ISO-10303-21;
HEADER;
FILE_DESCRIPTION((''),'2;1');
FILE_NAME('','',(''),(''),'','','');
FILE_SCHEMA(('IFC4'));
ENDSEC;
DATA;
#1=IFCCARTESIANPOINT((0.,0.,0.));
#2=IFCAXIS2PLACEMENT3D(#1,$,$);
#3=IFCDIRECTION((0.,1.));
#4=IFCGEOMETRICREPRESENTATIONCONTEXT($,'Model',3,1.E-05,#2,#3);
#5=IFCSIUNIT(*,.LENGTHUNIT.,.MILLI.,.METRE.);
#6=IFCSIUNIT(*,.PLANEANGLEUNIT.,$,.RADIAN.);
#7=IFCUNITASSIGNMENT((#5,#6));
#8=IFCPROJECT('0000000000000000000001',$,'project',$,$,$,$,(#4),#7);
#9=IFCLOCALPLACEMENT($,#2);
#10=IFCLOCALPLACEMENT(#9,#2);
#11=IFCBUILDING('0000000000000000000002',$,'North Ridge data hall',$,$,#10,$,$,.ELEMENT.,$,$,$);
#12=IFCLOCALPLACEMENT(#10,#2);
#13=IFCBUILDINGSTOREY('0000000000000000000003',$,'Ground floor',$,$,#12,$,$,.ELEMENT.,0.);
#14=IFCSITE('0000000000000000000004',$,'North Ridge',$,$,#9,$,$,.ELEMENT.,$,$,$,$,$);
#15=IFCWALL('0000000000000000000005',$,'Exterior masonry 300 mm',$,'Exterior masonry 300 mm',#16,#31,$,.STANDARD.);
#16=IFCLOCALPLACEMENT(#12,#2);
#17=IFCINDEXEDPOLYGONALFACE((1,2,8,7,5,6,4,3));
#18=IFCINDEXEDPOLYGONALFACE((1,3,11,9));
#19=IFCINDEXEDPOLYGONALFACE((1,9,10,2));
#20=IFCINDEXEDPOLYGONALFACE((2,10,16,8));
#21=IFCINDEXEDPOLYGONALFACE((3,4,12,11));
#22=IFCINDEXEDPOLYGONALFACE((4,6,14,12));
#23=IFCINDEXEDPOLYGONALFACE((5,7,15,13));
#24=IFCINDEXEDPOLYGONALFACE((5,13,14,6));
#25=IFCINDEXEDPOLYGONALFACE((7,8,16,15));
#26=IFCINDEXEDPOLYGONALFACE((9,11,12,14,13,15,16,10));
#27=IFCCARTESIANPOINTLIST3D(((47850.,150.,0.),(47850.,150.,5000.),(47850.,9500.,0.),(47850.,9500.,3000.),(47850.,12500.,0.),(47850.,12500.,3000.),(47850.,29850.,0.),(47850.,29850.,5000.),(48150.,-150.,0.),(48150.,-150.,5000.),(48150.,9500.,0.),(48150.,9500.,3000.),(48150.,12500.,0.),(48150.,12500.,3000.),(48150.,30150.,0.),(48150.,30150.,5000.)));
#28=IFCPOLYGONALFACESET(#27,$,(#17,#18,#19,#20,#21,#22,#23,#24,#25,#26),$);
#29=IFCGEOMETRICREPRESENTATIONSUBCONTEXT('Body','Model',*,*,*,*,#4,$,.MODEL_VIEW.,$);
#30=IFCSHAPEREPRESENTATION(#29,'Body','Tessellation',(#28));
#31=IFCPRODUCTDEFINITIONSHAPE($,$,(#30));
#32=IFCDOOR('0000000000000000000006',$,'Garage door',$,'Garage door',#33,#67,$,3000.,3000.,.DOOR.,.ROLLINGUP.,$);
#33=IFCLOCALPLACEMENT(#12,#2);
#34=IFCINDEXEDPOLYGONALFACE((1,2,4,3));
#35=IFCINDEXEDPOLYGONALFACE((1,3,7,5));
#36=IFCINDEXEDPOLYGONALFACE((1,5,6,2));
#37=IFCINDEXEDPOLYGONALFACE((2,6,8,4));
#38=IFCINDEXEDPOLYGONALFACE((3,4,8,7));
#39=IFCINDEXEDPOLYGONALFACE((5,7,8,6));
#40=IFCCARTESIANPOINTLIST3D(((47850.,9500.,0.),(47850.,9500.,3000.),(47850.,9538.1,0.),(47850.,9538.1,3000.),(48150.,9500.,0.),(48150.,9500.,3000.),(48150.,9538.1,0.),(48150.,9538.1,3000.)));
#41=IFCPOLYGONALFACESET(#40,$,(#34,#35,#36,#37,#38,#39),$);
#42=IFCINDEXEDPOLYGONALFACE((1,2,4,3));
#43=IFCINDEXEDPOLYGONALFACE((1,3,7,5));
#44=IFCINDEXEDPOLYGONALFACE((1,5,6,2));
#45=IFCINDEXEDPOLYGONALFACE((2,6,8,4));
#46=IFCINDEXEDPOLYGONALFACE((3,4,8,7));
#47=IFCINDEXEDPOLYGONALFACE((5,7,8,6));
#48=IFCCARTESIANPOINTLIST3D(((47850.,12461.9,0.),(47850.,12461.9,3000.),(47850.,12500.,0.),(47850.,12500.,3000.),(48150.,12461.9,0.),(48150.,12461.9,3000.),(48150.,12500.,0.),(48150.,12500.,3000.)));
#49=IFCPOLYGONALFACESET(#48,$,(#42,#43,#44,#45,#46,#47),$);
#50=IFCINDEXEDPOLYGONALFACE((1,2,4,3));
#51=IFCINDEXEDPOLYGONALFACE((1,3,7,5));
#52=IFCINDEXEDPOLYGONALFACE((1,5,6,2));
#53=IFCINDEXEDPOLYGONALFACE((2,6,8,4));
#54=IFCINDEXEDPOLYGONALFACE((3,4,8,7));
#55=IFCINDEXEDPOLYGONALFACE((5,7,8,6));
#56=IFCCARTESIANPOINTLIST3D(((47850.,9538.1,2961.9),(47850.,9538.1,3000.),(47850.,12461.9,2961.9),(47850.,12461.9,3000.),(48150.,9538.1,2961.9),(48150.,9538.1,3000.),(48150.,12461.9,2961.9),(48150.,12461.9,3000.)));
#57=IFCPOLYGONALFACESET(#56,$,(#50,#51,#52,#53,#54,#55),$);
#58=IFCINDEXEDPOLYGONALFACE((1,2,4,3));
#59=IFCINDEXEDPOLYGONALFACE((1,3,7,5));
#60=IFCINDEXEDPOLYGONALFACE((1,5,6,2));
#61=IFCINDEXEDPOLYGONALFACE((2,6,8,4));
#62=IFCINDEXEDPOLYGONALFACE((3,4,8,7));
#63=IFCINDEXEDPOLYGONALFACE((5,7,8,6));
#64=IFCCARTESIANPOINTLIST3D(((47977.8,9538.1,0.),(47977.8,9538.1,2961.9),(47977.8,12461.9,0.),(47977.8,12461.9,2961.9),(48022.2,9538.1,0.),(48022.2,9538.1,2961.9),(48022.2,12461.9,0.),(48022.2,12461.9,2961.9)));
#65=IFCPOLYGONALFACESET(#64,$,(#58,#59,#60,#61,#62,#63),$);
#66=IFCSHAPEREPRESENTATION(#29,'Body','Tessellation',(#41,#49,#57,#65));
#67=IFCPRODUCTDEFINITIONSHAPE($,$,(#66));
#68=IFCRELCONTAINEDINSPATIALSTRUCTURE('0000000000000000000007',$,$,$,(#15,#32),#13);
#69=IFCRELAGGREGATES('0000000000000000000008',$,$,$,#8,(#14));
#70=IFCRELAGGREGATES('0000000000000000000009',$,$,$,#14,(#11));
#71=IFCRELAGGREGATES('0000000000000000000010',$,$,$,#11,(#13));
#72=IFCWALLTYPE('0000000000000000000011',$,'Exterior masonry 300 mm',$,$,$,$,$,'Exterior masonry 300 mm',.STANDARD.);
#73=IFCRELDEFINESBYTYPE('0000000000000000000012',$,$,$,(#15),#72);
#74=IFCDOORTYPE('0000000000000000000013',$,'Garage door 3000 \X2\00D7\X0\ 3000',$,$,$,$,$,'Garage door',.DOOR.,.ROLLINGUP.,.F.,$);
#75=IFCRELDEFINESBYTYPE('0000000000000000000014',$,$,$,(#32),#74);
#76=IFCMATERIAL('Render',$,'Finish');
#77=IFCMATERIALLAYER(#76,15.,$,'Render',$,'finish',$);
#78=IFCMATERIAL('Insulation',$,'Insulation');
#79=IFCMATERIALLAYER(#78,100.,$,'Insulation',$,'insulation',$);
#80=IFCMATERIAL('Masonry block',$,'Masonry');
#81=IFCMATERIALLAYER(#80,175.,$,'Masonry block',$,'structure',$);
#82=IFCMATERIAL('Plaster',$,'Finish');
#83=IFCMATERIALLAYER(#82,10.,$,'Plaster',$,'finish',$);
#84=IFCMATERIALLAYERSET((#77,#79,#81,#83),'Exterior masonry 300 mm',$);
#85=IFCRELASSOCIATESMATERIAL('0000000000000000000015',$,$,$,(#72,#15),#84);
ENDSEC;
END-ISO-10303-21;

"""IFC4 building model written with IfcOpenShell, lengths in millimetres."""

from ifc_helpers import new_model, si_unit, direction, frame, origin, origin_with_axes, place, context, subcontext, project, spatial, polyline, outline, extrude, material, layer, layer_set, layer_usage, type_object, element, fill, save


model = new_model("IFC4")

# Units and contexts
model_context = context("Model", 3, precision=1e-05, world=origin(), true_north=direction((0.0, 1.0)))
body_context = subcontext(model_context, "Body", "Model", "MODEL_VIEW")
ifc_project = project(units=[si_unit("LENGTHUNIT", "METRE", prefix="MILLI"), si_unit("PLANEANGLEUNIT", "RADIAN")], contexts=[model_context])

# Site, building, storey
site_placement = place(None, origin())
site = spatial("IfcSite", under=ifc_project, at=site_placement, Name="North Ridge", CompositionType="ELEMENT")
building_placement = place(site_placement, origin())
building = spatial("IfcBuilding", under=site, at=building_placement, Name="North Ridge data hall", CompositionType="ELEMENT")
storey_placement = place(building_placement, origin())
storey = spatial("IfcBuildingStorey", under=building, at=storey_placement, Name="Ground floor", CompositionType="ELEMENT", Elevation=0.0)

# Wall, opening, door
ifc_material_1 = material(Name="Render", Category="Finish")
ifc_layer_1 = layer(ifc_material_1, 15.0, Name="Render", Category="finish")
ifc_material_2 = material(Name="Insulation", Category="Insulation")
ifc_layer_2 = layer(ifc_material_2, 100.0, Name="Insulation", Category="insulation")
ifc_material_3 = material(Name="Masonry block", Category="Masonry")
ifc_layer_3 = layer(ifc_material_3, 175.0, Name="Masonry block", Category="structure")
ifc_material_4 = material(Name="Plaster", Category="Finish")
ifc_layer_4 = layer(ifc_material_4, 10.0, Name="Plaster", Category="finish")
ifc_layer_set = layer_set([ifc_layer_1, ifc_layer_2, ifc_layer_3, ifc_layer_4], Name="Exterior masonry 300 mm")
ifc_layer_usage = layer_usage(ifc_layer_set, "AXIS2", "POSITIVE", -150.0)
wall_type = type_object("IfcWallType", Name="Exterior masonry 300 mm", ElementType="Exterior masonry 300 mm", PredefinedType="STANDARD", material=ifc_layer_set)
wall_placement = place(storey_placement, frame((48000.0, 0.0, 0.0), z_axis=(0.0, 0.0, 1.0), x_axis=(0.0, 1.0, 0.0)))
wall = element("IfcWall", 1, at=wall_placement, inside=storey, type_object=wall_type, material=ifc_layer_usage, Name="Exterior masonry 300 mm", ObjectType="Exterior masonry 300 mm", PredefinedType="STANDARD", context=body_context, shape_type="SweptSolid", body=[
    extrude(outline(polyline([(-150.0, -150.0), (30150.0, -150.0), (29850.0, 150.0), (150.0, 150.0), (-150.0, -150.0)])), origin(), (0.0, 0.0, 1.0), 5000.0),
])
opening_placement = place(wall_placement, frame((9500.0, 0.0, 0.0), z_axis=(0.0, 0.0, 1.0), x_axis=(1.0, 0.0, 0.0)))
opening = element("IfcOpeningElement", 2, at=opening_placement, cuts=wall, PredefinedType="OPENING", context=body_context, shape_type="SweptSolid", body=[
    extrude(outline(polyline([(0.0, -160.0), (3000.0, -160.0), (3000.0, 160.0), (0.0, 160.0), (0.0, -160.0)])), origin(), (0.0, 0.0, 1.0), 3000.0),
])
door_type = type_object("IfcDoorType", Name="Garage door 3000 × 3000", ElementType="Garage door", OperationType="ROLLINGUP", ParameterTakesPrecedence=False, PredefinedType="DOOR")
door_placement = place(opening_placement, origin_with_axes())
door = element("IfcDoor", 3, at=door_placement, inside=storey, type_object=door_type, Name="Garage door", ObjectType="Garage door", OperationType="ROLLINGUP", OverallHeight=3000.0, OverallWidth=3000.0, PredefinedType="DOOR", context=body_context, shape_type="SweptSolid", body=[
    extrude(outline(polyline([(0.0, -150.0), (38.1, -150.0), (38.1, 150.0), (0.0, 150.0), (0.0, -150.0)])), origin(), (0.0, 0.0, 1.0), 3000.0),
    extrude(outline(polyline([(2961.9, -150.0), (3000.0, -150.0), (3000.0, 150.0), (2961.9, 150.0), (2961.9, -150.0)])), origin(), (0.0, 0.0, 1.0), 3000.0),
    extrude(outline(polyline([(38.1, -150.0), (2961.9, -150.0), (2961.9, 150.0), (38.1, 150.0), (38.1, -150.0)])), frame((0.0, 0.0, 2961.9)), (0.0, 0.0, 1.0), 38.1),
    extrude(outline(polyline([(38.1, -22.2), (2961.9, -22.2), (2961.9, 22.2), (38.1, 22.2), (38.1, -22.2)])), origin(), (0.0, 0.0, 1.0), 2961.9),
])
fill(opening, door)

save(model, "model.ifc")
